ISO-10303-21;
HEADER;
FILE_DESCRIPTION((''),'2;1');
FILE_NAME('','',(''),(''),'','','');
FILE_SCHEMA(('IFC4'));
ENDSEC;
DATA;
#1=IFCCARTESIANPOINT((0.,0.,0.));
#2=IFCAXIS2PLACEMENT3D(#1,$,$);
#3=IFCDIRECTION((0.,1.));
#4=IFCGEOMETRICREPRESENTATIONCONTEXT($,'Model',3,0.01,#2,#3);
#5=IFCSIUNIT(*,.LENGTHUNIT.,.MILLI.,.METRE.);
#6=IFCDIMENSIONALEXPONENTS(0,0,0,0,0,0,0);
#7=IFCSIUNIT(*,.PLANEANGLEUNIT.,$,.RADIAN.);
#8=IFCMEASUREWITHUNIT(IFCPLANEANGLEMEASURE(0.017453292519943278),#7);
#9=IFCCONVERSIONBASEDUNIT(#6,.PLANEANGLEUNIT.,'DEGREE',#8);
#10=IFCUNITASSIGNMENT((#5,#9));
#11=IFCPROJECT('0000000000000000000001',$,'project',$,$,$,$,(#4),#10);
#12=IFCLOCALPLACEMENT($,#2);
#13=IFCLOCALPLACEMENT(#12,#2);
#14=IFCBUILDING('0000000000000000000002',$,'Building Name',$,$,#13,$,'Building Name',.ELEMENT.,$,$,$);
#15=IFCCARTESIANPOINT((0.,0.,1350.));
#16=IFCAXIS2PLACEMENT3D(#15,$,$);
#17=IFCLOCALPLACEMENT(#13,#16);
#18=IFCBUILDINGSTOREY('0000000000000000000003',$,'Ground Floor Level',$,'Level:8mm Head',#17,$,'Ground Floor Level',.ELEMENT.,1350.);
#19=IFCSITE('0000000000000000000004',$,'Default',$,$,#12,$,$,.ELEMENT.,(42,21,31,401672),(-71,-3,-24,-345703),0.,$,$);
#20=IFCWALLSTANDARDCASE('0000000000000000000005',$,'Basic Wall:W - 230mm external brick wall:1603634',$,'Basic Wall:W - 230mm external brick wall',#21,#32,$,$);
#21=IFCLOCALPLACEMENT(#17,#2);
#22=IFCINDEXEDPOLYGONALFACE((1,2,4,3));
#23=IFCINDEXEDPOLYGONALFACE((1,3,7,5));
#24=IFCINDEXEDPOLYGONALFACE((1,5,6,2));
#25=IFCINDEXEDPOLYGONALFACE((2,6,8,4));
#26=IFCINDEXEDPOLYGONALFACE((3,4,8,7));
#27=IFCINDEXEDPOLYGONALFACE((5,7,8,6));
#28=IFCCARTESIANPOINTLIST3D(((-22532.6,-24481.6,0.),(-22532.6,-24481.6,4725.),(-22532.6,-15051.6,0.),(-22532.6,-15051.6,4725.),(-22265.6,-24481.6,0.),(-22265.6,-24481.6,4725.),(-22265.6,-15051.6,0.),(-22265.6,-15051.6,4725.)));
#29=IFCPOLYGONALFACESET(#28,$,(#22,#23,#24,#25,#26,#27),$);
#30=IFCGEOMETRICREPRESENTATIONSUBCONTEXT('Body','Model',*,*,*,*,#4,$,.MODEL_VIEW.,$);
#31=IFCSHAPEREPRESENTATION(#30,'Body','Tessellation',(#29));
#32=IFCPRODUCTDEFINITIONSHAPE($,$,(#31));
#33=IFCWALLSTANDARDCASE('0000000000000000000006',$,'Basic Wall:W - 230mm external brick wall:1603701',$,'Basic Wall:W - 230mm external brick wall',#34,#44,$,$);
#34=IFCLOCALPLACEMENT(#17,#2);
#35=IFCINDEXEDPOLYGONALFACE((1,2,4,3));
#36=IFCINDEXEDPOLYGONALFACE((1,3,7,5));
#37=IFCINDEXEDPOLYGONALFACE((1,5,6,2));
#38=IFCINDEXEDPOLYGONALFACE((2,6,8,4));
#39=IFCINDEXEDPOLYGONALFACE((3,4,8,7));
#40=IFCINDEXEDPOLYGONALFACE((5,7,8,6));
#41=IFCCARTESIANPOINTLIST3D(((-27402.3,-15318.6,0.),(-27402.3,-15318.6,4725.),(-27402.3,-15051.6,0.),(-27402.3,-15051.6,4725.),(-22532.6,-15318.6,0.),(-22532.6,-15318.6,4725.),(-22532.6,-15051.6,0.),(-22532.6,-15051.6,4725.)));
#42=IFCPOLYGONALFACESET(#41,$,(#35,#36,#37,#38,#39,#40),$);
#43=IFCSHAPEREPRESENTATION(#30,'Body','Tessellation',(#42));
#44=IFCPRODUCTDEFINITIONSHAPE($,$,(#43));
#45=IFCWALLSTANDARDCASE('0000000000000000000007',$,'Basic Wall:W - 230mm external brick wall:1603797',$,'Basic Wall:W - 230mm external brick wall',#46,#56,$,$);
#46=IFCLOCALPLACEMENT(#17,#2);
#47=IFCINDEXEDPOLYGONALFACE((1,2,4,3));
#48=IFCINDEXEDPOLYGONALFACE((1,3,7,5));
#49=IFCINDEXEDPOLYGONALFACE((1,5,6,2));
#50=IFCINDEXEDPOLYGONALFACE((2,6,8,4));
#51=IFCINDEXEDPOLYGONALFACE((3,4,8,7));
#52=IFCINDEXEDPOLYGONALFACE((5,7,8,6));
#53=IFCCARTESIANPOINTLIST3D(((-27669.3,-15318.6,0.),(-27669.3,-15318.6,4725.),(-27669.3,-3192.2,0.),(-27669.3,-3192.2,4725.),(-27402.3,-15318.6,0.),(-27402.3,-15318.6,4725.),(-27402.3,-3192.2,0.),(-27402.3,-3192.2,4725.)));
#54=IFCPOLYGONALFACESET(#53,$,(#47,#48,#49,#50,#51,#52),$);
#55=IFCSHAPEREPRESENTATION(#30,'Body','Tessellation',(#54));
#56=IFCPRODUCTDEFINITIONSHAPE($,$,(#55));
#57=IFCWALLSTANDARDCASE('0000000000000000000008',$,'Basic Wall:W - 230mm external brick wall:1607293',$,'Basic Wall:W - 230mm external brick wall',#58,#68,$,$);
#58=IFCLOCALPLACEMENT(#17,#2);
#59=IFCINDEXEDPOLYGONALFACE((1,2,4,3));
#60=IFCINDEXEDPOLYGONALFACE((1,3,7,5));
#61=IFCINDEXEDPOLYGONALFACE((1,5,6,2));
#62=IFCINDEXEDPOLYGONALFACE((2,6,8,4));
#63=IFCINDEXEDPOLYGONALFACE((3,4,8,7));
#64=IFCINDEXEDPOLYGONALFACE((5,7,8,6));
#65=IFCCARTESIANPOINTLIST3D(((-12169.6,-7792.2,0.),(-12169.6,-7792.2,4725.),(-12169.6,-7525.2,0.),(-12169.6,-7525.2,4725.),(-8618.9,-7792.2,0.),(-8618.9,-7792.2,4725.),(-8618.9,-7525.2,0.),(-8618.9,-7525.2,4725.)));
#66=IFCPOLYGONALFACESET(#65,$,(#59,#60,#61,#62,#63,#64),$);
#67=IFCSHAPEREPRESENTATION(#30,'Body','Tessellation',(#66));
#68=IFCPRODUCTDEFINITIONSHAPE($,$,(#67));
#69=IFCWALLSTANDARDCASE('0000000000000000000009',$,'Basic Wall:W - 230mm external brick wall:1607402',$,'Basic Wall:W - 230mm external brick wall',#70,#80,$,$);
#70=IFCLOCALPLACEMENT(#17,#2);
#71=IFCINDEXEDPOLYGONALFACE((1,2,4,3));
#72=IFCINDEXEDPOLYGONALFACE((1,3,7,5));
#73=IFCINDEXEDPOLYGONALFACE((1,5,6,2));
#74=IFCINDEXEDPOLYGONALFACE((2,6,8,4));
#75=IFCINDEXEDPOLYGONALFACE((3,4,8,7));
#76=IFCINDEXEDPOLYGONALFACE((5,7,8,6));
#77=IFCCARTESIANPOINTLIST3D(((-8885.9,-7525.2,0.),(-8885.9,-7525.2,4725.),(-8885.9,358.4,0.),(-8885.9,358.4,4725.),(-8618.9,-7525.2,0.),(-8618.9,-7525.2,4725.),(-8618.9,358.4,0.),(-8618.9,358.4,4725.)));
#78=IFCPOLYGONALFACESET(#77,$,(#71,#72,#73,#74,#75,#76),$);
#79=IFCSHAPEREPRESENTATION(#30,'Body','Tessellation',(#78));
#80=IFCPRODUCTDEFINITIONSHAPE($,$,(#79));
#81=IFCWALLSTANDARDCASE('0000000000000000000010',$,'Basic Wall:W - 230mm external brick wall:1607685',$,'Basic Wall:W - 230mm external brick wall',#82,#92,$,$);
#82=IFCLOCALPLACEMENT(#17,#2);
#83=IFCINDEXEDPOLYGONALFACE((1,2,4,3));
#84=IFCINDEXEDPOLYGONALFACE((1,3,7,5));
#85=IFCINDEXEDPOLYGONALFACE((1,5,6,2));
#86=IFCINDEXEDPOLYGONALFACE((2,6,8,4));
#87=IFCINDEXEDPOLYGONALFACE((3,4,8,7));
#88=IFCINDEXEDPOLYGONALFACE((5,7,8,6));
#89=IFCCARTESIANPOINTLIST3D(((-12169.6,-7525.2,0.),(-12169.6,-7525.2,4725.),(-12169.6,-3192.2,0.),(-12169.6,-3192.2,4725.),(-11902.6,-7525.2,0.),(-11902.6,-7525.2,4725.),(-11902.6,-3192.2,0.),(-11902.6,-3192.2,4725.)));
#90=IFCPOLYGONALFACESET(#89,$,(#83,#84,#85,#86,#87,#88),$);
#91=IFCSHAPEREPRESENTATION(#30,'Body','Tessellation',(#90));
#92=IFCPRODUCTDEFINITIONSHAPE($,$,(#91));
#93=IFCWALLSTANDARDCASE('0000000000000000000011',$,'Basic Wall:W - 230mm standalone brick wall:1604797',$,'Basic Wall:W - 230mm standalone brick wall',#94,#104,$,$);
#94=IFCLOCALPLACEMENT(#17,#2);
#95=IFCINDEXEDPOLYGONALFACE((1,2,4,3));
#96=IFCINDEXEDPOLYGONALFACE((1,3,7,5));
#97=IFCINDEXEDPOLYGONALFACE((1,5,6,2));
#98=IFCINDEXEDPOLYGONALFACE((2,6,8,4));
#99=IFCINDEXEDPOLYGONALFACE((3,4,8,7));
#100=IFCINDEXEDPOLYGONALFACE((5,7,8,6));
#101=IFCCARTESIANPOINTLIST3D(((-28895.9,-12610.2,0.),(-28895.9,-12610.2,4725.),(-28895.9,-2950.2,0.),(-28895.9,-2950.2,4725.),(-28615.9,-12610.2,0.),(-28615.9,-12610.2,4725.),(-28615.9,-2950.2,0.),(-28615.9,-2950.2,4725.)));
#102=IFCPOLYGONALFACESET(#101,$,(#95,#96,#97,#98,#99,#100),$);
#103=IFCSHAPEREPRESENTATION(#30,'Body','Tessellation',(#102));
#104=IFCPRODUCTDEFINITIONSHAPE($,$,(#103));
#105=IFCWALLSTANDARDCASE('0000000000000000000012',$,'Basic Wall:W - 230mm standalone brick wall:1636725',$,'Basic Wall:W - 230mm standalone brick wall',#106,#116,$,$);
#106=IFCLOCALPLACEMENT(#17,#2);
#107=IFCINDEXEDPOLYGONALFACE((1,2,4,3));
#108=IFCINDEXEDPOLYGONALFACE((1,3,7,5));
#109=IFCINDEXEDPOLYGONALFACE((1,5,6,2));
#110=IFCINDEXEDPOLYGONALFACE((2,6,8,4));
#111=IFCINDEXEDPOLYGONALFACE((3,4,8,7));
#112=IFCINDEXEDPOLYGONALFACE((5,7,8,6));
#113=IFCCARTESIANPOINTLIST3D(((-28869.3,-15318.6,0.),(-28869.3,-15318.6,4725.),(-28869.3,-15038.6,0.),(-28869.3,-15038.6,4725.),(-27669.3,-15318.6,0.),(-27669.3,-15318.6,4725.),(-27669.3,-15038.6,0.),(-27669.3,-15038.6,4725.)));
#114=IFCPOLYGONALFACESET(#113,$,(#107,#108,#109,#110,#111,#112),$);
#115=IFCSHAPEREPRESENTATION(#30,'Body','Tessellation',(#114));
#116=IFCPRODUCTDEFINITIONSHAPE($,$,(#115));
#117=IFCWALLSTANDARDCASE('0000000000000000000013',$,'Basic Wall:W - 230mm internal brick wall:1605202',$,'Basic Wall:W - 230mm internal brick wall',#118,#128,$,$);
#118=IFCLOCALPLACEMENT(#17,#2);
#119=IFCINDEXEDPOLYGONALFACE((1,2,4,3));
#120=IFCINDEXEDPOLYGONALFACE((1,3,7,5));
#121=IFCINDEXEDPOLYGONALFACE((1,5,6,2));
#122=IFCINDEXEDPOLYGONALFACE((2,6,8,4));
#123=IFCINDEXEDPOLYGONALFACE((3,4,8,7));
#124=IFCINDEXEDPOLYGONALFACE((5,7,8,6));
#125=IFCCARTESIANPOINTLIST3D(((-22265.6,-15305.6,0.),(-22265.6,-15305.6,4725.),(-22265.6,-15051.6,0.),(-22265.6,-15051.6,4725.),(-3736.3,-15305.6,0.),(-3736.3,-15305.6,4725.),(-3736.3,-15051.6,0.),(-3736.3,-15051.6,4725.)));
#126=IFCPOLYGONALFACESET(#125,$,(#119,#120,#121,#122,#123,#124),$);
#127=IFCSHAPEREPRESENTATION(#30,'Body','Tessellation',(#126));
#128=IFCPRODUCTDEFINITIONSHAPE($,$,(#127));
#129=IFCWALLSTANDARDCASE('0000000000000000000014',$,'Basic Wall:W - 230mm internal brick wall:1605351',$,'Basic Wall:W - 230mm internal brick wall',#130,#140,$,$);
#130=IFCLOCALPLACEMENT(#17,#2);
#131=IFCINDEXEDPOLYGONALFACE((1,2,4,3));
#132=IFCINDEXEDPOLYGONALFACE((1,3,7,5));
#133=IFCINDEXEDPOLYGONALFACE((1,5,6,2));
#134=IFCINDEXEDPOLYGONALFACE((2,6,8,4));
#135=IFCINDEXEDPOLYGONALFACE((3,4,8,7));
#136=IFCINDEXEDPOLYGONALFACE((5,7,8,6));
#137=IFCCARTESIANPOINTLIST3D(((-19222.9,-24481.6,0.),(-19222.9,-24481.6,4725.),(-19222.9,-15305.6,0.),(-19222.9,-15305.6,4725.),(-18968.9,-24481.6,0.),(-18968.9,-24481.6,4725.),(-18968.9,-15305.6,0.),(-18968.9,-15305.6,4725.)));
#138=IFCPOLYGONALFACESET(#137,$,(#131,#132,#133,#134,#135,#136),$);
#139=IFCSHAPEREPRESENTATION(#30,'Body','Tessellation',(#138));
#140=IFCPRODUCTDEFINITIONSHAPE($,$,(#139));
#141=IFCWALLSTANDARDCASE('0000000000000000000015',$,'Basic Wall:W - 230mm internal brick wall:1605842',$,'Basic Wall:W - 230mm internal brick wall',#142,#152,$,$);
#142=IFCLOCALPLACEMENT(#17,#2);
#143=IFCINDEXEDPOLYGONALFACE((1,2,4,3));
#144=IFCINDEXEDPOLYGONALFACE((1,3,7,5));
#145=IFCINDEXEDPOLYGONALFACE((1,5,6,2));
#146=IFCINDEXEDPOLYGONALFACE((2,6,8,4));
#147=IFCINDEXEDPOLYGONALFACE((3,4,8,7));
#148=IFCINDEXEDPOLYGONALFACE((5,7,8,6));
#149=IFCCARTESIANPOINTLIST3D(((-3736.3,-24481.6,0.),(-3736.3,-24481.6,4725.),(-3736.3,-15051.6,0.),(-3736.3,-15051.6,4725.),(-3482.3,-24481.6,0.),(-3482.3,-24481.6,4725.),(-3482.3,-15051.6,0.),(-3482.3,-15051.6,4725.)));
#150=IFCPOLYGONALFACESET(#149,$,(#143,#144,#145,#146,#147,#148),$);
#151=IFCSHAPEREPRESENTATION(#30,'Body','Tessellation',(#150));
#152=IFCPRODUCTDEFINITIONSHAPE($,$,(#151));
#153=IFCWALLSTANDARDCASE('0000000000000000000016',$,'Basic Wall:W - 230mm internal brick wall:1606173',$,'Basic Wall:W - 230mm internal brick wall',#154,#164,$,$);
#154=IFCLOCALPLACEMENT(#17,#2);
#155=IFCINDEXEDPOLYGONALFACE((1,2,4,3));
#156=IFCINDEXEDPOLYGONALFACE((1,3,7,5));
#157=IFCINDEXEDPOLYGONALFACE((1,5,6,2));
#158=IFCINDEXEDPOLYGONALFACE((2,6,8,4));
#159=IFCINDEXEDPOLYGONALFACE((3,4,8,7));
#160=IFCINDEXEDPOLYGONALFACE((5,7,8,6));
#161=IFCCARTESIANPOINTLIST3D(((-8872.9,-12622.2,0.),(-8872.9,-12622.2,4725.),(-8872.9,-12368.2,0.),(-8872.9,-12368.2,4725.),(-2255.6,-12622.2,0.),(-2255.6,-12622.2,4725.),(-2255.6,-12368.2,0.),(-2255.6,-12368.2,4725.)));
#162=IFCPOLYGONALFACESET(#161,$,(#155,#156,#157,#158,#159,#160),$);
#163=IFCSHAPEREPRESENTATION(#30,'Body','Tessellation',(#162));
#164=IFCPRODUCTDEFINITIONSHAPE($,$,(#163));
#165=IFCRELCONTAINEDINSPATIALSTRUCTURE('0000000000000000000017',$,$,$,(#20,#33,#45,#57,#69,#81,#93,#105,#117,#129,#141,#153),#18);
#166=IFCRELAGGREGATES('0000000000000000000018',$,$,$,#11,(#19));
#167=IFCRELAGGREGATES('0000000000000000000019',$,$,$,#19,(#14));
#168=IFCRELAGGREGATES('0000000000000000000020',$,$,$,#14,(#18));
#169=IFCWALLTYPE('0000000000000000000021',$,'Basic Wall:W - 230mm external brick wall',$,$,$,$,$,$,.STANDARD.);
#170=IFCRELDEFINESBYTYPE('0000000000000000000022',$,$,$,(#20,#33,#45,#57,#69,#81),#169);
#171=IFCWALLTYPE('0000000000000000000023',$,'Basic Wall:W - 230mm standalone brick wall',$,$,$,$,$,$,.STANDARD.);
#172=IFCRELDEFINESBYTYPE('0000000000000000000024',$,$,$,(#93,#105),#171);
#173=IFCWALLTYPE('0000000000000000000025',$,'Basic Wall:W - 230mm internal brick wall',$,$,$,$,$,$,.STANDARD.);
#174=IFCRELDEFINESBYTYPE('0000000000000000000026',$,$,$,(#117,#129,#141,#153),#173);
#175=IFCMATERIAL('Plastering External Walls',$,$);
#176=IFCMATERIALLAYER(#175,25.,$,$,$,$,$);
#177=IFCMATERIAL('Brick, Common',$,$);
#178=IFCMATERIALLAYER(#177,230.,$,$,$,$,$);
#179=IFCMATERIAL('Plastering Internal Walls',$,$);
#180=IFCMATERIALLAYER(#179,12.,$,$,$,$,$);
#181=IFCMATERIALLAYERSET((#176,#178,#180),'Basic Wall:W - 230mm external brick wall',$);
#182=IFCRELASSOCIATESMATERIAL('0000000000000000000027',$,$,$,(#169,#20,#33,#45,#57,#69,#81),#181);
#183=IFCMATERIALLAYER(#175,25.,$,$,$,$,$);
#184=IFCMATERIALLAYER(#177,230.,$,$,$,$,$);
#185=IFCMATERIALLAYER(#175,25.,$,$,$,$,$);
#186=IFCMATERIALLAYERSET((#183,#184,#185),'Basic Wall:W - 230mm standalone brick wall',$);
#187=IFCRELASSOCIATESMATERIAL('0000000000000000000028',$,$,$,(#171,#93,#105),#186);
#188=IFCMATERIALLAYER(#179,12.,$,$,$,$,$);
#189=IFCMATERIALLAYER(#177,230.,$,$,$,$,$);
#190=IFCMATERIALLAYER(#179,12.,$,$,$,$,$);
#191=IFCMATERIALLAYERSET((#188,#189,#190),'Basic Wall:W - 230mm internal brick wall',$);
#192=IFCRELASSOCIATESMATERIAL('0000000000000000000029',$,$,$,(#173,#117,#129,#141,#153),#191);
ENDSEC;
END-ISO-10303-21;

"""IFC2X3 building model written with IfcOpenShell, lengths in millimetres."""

from ifc_helpers import new_model, entity, si_unit, converted_unit, direction, frame, frame_2d, origin, place, context, subcontext, project, spatial, rectangle, extrude, material, layer, layer_set, layer_usage, type_object, element, save


model = new_model("IFC2X3")

# Units and contexts
model_context = context("Model", 3, precision=0.01, world=origin(), true_north=direction((0.0, 1.0)))
body_context = subcontext(model_context, "Body", "Model", "MODEL_VIEW")
ifc_project = project(units=[si_unit("LENGTHUNIT", "METRE", prefix="MILLI"), converted_unit("PLANEANGLEUNIT", "DEGREE", entity("IfcPlaneAngleMeasure", 0.017453292519943278), si_unit("PLANEANGLEUNIT", "RADIAN"), dimensions=[0, 0, 0, 0, 0, 0, 0])], contexts=[model_context])

# Site, building, storey
site_placement = place(None, origin())
site = spatial("IfcSite", under=ifc_project, at=site_placement, Name="Default", CompositionType="ELEMENT", RefLatitude=(42, 21, 31, 401672), RefLongitude=(-71, -3, -24, -345703), RefElevation=0.0)
building_placement = place(site_placement, origin())
building = spatial("IfcBuilding", under=site, at=building_placement, Name="Building Name", LongName="Building Name", CompositionType="ELEMENT")
storey_placement = place(building_placement, frame((0.0, 0.0, 1350.0)))
storey = spatial("IfcBuildingStorey", under=building, at=storey_placement, Name="Ground Floor Level", ObjectType="Level:8mm Head", LongName="Ground Floor Level", CompositionType="ELEMENT", Elevation=1350.0)

# Walls
ifc_material_1 = material(Name="Plastering External Walls")
ifc_layer_1 = layer(ifc_material_1, 25.0)
ifc_material_2 = material(Name="Brick, Common")
ifc_layer_2 = layer(ifc_material_2, 230.0)
ifc_material_3 = material(Name="Plastering Internal Walls")
ifc_layer_3 = layer(ifc_material_3, 12.0)
ifc_layer_set_1 = layer_set([ifc_layer_1, ifc_layer_2, ifc_layer_3], Name="Basic Wall:W - 230mm external brick wall")
ifc_layer_usage_1 = layer_usage(ifc_layer_set_1, "AXIS2", "NEGATIVE", 133.5)
wall_type_1 = type_object("IfcWallType", Name="Basic Wall:W - 230mm external brick wall", PredefinedType="STANDARD", material=ifc_layer_set_1)
wall_1_placement = place(storey_placement, frame((-22399.1, -24481.6, 0.0), z_axis=(0.0, 0.0, 1.0), x_axis=(0.0, 1.0, 0.0)))
element("IfcWallStandardCase", 1, at=wall_1_placement, inside=storey, type_object=wall_type_1, material=ifc_layer_usage_1, Name="Basic Wall:W - 230mm external brick wall:1603634", ObjectType="Basic Wall:W - 230mm external brick wall", context=body_context, shape_type="SweptSolid", body=[
    extrude(rectangle(XDim=9430.0, YDim=267.0, at=frame_2d((4715.0, 0.0), x_axis=(-1.0, 0.0))), origin(), (0.0, 0.0, 1.0), 4725.0),
])
ifc_layer_usage_2 = layer_usage(ifc_layer_set_1, "AXIS2", "NEGATIVE", 133.5)
wall_2_placement = place(storey_placement, frame((-22532.6, -15185.1, 0.0), z_axis=(0.0, 0.0, 1.0), x_axis=(-1.0, 0.0, 0.0)))
element("IfcWallStandardCase", 2, at=wall_2_placement, inside=storey, type_object=wall_type_1, material=ifc_layer_usage_2, Name="Basic Wall:W - 230mm external brick wall:1603701", ObjectType="Basic Wall:W - 230mm external brick wall", context=body_context, shape_type="SweptSolid", body=[
    extrude(rectangle(XDim=4869.7, YDim=267.0, at=frame_2d((2434.8, 0.0), x_axis=(-1.0, 0.0))), origin(), (0.0, 0.0, 1.0), 4725.0),
])
ifc_layer_usage_3 = layer_usage(ifc_layer_set_1, "AXIS2", "NEGATIVE", 133.5)
wall_3_placement = place(storey_placement, frame((-27535.8, -15318.6, 0.0), z_axis=(0.0, 0.0, 1.0), x_axis=(0.0, 1.0, 0.0)))
element("IfcWallStandardCase", 3, at=wall_3_placement, inside=storey, type_object=wall_type_1, material=ifc_layer_usage_3, Name="Basic Wall:W - 230mm external brick wall:1603797", ObjectType="Basic Wall:W - 230mm external brick wall", context=body_context, shape_type="SweptSolid", body=[
    extrude(rectangle(XDim=12126.3, YDim=267.0, at=frame_2d((6063.2, 0.0), x_axis=(-1.0, 0.0))), origin(), (0.0, 0.0, 1.0), 4725.0),
])
ifc_layer_usage_4 = layer_usage(ifc_layer_set_1, "AXIS2", "NEGATIVE", 133.5)
wall_4_placement = place(storey_placement, frame((-12169.6, -7658.7, 0.0)))
element("IfcWallStandardCase", 4, at=wall_4_placement, inside=storey, type_object=wall_type_1, material=ifc_layer_usage_4, Name="Basic Wall:W - 230mm external brick wall:1607293", ObjectType="Basic Wall:W - 230mm external brick wall", context=body_context, shape_type="SweptSolid", body=[
    extrude(rectangle(XDim=3550.7, YDim=267.0, at=frame_2d((1775.3, 0.0), x_axis=(-1.0, 0.0))), origin(), (0.0, 0.0, 1.0), 4725.0),
])
ifc_layer_usage_5 = layer_usage(ifc_layer_set_1, "AXIS2", "NEGATIVE", 133.5)
wall_5_placement = place(storey_placement, frame((-8752.4, -7525.2, 0.0), z_axis=(0.0, 0.0, 1.0), x_axis=(0.0, 1.0, 0.0)))
element("IfcWallStandardCase", 5, at=wall_5_placement, inside=storey, type_object=wall_type_1, material=ifc_layer_usage_5, Name="Basic Wall:W - 230mm external brick wall:1607402", ObjectType="Basic Wall:W - 230mm external brick wall", context=body_context, shape_type="SweptSolid", body=[
    extrude(rectangle(XDim=7883.7, YDim=267.0, at=frame_2d((3941.8, 0.0), x_axis=(-1.0, 0.0))), origin(), (0.0, 0.0, 1.0), 4725.0),
])
ifc_layer_usage_6 = layer_usage(ifc_layer_set_1, "AXIS2", "NEGATIVE", 133.5)
wall_6_placement = place(storey_placement, frame((-12036.1, -3192.2, 0.0), z_axis=(0.0, 0.0, 1.0), x_axis=(0.0, -1.0, 0.0)))
element("IfcWallStandardCase", 6, at=wall_6_placement, inside=storey, type_object=wall_type_1, material=ifc_layer_usage_6, Name="Basic Wall:W - 230mm external brick wall:1607685", ObjectType="Basic Wall:W - 230mm external brick wall", context=body_context, shape_type="SweptSolid", body=[
    extrude(rectangle(XDim=4333.0, YDim=267.0, at=frame_2d((2166.5, 0.0), x_axis=(-1.0, 0.0))), origin(), (0.0, 0.0, 1.0), 4725.0),
])
ifc_layer_4 = layer(ifc_material_1, 25.0)
ifc_layer_5 = layer(ifc_material_2, 230.0)
ifc_layer_6 = layer(ifc_material_1, 25.0)
ifc_layer_set_2 = layer_set([ifc_layer_4, ifc_layer_5, ifc_layer_6], Name="Basic Wall:W - 230mm standalone brick wall")
ifc_layer_usage_7 = layer_usage(ifc_layer_set_2, "AXIS2", "NEGATIVE", 140.0)
wall_type_2 = type_object("IfcWallType", Name="Basic Wall:W - 230mm standalone brick wall", PredefinedType="STANDARD", material=ifc_layer_set_2)
wall_7_placement = place(storey_placement, frame((-28755.9, -12610.2, 0.0), z_axis=(0.0, 0.0, 1.0), x_axis=(0.0, 1.0, 0.0)))
element("IfcWallStandardCase", 7, at=wall_7_placement, inside=storey, type_object=wall_type_2, material=ifc_layer_usage_7, Name="Basic Wall:W - 230mm standalone brick wall:1604797", ObjectType="Basic Wall:W - 230mm standalone brick wall", context=body_context, shape_type="SweptSolid", body=[
    extrude(rectangle(XDim=9660.0, YDim=280.0, at=frame_2d((4830.0, 0.0), x_axis=(-1.0, 0.0))), origin(), (0.0, 0.0, 1.0), 4725.0),
])
ifc_layer_usage_8 = layer_usage(ifc_layer_set_2, "AXIS2", "NEGATIVE", 140.0)
wall_8_placement = place(storey_placement, frame((-28869.3, -15178.6, 0.0)))
element("IfcWallStandardCase", 8, at=wall_8_placement, inside=storey, type_object=wall_type_2, material=ifc_layer_usage_8, Name="Basic Wall:W - 230mm standalone brick wall:1636725", ObjectType="Basic Wall:W - 230mm standalone brick wall", context=body_context, shape_type="SweptSolid", body=[
    extrude(rectangle(XDim=1200.0, YDim=280.0, at=frame_2d((600.0, 0.0), x_axis=(-1.0, 0.0))), origin(), (0.0, 0.0, 1.0), 4725.0),
])
ifc_layer_7 = layer(ifc_material_3, 12.0)
ifc_layer_8 = layer(ifc_material_2, 230.0)
ifc_layer_9 = layer(ifc_material_3, 12.0)
ifc_layer_set_3 = layer_set([ifc_layer_7, ifc_layer_8, ifc_layer_9], Name="Basic Wall:W - 230mm internal brick wall")
ifc_layer_usage_9 = layer_usage(ifc_layer_set_3, "AXIS2", "NEGATIVE", 127.0)
wall_type_3 = type_object("IfcWallType", Name="Basic Wall:W - 230mm internal brick wall", PredefinedType="STANDARD", material=ifc_layer_set_3)
wall_9_placement = place(storey_placement, frame((-3736.3, -15178.6, 0.0), z_axis=(0.0, 0.0, 1.0), x_axis=(-1.0, 0.0, 0.0)))
element("IfcWallStandardCase", 9, at=wall_9_placement, inside=storey, type_object=wall_type_3, material=ifc_layer_usage_9, Name="Basic Wall:W - 230mm internal brick wall:1605202", ObjectType="Basic Wall:W - 230mm internal brick wall", context=body_context, shape_type="SweptSolid", body=[
    extrude(rectangle(XDim=18529.3, YDim=254.0, at=frame_2d((9264.7, 0.0), x_axis=(-1.0, 0.0))), origin(), (0.0, 0.0, 1.0), 4725.0),
])
ifc_layer_usage_10 = layer_usage(ifc_layer_set_3, "AXIS2", "NEGATIVE", 127.0)
wall_10_placement = place(storey_placement, frame((-19095.9, -24481.6, 0.0), z_axis=(0.0, 0.0, 1.0), x_axis=(0.0, 1.0, 0.0)))
element("IfcWallStandardCase", 10, at=wall_10_placement, inside=storey, type_object=wall_type_3, material=ifc_layer_usage_10, Name="Basic Wall:W - 230mm internal brick wall:1605351", ObjectType="Basic Wall:W - 230mm internal brick wall", context=body_context, shape_type="SweptSolid", body=[
    extrude(rectangle(XDim=9176.0, YDim=254.0, at=frame_2d((4588.0, 0.0), x_axis=(-1.0, 0.0))), origin(), (0.0, 0.0, 1.0), 4725.0),
])
ifc_layer_usage_11 = layer_usage(ifc_layer_set_3, "AXIS2", "NEGATIVE", 127.0)
wall_11_placement = place(storey_placement, frame((-3609.3, -24481.6, 0.0), z_axis=(0.0, 0.0, 1.0), x_axis=(0.0, 1.0, 0.0)))
element("IfcWallStandardCase", 11, at=wall_11_placement, inside=storey, type_object=wall_type_3, material=ifc_layer_usage_11, Name="Basic Wall:W - 230mm internal brick wall:1605842", ObjectType="Basic Wall:W - 230mm internal brick wall", context=body_context, shape_type="SweptSolid", body=[
    extrude(rectangle(XDim=9430.0, YDim=254.0, at=frame_2d((4715.0, 0.0), x_axis=(-1.0, 0.0))), origin(), (0.0, 0.0, 1.0), 4725.0),
])
ifc_layer_usage_12 = layer_usage(ifc_layer_set_3, "AXIS2", "NEGATIVE", 127.0)
wall_12_placement = place(storey_placement, frame((-2255.6, -12495.2, 0.0), z_axis=(0.0, 0.0, 1.0), x_axis=(-1.0, 0.0, 0.0)))
element("IfcWallStandardCase", 12, at=wall_12_placement, inside=storey, type_object=wall_type_3, material=ifc_layer_usage_12, Name="Basic Wall:W - 230mm internal brick wall:1606173", ObjectType="Basic Wall:W - 230mm internal brick wall", context=body_context, shape_type="SweptSolid", body=[
    extrude(rectangle(XDim=6617.3, YDim=254.0, at=frame_2d((3308.7, 0.0), x_axis=(-1.0, 0.0))), origin(), (0.0, 0.0, 1.0), 4725.0),
])

save(model, "model.ifc")
